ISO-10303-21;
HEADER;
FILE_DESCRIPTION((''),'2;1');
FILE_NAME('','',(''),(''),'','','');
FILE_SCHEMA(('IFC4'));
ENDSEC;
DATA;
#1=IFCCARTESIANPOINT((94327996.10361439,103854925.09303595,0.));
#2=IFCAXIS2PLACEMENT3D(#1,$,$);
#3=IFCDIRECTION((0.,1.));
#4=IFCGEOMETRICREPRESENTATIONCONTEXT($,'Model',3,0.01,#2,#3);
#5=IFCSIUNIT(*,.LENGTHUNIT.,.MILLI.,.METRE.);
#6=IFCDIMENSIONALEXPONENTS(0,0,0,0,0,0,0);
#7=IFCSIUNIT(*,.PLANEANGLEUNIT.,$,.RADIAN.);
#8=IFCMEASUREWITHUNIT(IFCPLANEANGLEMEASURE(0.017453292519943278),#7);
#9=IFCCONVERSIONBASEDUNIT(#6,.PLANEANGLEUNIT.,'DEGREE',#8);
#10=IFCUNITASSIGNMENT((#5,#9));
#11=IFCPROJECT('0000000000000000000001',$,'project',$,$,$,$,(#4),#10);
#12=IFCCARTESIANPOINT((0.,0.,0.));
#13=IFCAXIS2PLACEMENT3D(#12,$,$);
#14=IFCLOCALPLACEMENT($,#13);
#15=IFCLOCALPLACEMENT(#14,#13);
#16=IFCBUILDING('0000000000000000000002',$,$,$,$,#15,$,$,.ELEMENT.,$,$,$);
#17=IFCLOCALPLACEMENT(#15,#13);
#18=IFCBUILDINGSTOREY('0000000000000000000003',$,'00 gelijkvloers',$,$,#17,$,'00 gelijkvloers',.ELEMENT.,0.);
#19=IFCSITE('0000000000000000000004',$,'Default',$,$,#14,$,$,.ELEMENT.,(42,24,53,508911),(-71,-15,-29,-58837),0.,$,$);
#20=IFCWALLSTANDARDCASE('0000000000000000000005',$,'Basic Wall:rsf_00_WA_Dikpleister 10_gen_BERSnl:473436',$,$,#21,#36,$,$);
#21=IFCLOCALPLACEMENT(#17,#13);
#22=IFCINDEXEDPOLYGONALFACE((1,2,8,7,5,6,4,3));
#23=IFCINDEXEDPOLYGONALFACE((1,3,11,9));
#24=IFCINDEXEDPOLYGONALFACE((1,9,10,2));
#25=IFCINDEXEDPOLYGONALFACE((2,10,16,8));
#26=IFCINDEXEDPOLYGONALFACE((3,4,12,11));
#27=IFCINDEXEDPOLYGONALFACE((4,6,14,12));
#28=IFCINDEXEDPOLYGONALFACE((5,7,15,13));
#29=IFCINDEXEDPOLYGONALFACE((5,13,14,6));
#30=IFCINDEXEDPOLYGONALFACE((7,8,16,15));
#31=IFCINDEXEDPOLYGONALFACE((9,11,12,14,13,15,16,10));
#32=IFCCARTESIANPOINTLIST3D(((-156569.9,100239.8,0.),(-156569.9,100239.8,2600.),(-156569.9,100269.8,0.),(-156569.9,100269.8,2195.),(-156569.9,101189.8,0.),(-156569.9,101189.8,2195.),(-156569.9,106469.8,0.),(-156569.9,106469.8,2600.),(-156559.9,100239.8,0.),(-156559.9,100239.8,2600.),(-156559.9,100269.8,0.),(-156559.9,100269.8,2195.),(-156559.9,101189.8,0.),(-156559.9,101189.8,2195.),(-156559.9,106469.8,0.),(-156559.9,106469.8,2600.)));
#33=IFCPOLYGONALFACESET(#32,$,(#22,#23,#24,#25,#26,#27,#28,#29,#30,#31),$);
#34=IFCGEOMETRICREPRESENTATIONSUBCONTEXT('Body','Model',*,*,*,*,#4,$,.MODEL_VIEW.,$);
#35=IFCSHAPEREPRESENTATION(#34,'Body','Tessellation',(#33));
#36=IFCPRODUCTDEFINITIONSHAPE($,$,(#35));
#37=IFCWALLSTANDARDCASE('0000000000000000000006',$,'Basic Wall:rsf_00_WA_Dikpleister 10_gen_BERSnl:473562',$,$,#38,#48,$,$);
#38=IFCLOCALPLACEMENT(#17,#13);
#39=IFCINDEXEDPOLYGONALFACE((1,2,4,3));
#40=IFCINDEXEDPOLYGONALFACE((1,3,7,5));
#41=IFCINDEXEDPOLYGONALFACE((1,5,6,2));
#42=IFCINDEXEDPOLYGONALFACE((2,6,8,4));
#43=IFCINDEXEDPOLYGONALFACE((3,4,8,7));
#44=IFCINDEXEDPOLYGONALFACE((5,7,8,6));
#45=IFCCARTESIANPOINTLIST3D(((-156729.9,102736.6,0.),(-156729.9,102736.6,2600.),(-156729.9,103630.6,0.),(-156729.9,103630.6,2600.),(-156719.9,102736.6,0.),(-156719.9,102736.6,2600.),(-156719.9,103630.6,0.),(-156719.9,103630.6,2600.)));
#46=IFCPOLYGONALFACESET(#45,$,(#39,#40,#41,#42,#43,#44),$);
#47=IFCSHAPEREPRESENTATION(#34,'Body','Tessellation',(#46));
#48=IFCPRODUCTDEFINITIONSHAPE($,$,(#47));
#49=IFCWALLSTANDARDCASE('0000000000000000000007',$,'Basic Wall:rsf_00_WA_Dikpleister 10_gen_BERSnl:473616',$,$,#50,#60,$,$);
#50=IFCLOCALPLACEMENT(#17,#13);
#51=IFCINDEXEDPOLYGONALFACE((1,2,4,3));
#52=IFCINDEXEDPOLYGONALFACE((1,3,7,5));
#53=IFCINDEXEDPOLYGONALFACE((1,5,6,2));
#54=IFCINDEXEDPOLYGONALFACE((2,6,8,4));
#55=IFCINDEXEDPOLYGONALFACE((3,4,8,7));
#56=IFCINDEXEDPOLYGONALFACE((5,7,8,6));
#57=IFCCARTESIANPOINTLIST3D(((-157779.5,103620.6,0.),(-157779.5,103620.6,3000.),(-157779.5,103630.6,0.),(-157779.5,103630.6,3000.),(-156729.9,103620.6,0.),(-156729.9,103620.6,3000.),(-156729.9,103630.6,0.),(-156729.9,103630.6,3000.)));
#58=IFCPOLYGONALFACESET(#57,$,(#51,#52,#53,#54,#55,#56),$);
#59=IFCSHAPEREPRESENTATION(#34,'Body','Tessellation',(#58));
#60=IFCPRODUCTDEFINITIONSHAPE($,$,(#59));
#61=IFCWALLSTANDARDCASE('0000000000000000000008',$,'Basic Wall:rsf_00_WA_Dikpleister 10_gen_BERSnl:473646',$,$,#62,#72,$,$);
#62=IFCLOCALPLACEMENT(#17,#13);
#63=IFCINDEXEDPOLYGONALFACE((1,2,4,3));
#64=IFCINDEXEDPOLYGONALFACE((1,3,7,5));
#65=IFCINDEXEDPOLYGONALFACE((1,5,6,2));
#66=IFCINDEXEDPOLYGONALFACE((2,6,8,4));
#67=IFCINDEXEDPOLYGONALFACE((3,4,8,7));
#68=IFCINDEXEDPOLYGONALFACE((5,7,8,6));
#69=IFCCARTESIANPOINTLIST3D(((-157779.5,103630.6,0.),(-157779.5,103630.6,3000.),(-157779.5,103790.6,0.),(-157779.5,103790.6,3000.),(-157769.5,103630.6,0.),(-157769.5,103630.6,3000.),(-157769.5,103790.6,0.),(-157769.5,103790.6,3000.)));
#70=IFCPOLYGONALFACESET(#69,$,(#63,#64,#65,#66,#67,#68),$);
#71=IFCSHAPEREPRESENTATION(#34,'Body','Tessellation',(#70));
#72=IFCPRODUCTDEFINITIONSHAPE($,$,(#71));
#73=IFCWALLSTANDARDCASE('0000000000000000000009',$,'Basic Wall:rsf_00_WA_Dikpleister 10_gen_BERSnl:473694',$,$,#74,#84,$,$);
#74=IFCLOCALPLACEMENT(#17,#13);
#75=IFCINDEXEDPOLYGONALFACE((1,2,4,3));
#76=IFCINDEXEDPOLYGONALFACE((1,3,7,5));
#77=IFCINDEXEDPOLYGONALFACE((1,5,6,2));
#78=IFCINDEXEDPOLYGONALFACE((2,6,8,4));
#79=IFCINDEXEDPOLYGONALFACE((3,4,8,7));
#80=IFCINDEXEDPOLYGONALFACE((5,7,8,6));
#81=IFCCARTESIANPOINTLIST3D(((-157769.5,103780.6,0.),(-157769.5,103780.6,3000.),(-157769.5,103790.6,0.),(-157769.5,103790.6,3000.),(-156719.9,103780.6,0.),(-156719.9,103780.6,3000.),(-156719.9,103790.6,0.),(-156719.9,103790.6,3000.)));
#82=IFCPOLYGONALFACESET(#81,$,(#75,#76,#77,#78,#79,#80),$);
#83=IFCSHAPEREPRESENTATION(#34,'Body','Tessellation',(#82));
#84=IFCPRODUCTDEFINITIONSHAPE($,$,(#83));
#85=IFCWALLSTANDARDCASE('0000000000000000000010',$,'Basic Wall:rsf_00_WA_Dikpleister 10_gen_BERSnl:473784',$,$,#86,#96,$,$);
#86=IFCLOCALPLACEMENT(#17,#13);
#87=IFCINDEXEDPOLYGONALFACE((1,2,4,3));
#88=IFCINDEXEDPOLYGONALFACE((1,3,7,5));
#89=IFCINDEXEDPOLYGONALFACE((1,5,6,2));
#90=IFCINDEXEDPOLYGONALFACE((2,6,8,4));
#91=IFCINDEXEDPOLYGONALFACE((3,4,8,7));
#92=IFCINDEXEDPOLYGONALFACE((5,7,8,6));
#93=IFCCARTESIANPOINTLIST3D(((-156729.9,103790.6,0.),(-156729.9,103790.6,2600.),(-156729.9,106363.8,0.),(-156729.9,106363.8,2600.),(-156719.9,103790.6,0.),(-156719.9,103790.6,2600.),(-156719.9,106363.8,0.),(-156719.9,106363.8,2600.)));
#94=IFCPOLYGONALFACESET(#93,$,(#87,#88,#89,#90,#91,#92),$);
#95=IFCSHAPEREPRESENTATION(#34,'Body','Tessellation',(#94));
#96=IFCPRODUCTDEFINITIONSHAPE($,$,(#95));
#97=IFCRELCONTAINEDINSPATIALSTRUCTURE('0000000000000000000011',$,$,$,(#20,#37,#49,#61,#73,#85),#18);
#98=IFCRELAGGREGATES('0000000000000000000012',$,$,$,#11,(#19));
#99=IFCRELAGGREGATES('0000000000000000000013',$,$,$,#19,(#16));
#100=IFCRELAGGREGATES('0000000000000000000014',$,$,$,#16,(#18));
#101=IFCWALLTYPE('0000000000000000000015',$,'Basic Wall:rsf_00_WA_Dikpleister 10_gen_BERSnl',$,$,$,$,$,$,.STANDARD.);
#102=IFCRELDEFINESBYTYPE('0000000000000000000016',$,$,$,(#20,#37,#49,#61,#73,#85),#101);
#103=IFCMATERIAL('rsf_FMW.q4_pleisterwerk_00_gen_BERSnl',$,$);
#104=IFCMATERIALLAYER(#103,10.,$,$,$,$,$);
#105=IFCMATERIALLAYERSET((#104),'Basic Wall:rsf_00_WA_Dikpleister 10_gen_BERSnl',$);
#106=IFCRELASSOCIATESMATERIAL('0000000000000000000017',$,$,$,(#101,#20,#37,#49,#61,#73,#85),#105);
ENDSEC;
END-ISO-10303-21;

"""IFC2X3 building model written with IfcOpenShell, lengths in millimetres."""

from ifc_helpers import new_model, entity, si_unit, converted_unit, direction, frame, frame_2d, origin, place, context, subcontext, project, spatial, rectangle, extrude, material, layer, layer_set, layer_usage, type_object, element, save


model = new_model("IFC2X3")

# Units and contexts
model_context = context("Model", 3, precision=0.01, world=frame((94327996.10361439, 103854925.09303595, 0.0)), true_north=direction((0.0, 1.0)))
body_context = subcontext(model_context, "Body", "Model", "MODEL_VIEW")
ifc_project = project(units=[si_unit("LENGTHUNIT", "METRE", prefix="MILLI"), converted_unit("PLANEANGLEUNIT", "DEGREE", entity("IfcPlaneAngleMeasure", 0.017453292519943278), si_unit("PLANEANGLEUNIT", "RADIAN"), dimensions=[0, 0, 0, 0, 0, 0, 0])], contexts=[model_context])

# Site, building, storey
site_placement = place(None, origin())
site = spatial("IfcSite", under=ifc_project, at=site_placement, Name="Default", CompositionType="ELEMENT", RefLatitude=(42, 24, 53, 508911), RefLongitude=(-71, -15, -29, -58837), RefElevation=0.0)
building_placement = place(site_placement, origin())
building = spatial("IfcBuilding", under=site, at=building_placement, CompositionType="ELEMENT")
storey_placement = place(building_placement, origin())
storey = spatial("IfcBuildingStorey", under=building, at=storey_placement, Name="00 gelijkvloers", LongName="00 gelijkvloers", CompositionType="ELEMENT", Elevation=0.0)

# Shared definitions
ifc_material_1 = material(Name="rsf_FMW.q4_pleisterwerk_00_gen_BERSnl")

# Shared definitions
ifc_layer_1 = layer(ifc_material_1, 10.0)
ifc_layer_set_1 = layer_set([ifc_layer_1], Name="Basic Wall:rsf_00_WA_Dikpleister 10_gen_BERSnl")
wall_type_1 = type_object("IfcWallType", Name="Basic Wall:rsf_00_WA_Dikpleister 10_gen_BERSnl", PredefinedType="STANDARD", material=ifc_layer_set_1)

# Wall, opening
ifc_layer_usage_1 = layer_usage(ifc_layer_set_1, "AXIS2", "NEGATIVE", 5.0)
wall_1_placement = place(storey_placement, frame((-156564.9, 106469.8, 0.0), z_axis=(0.0, 0.0, 1.0), x_axis=(0.0, -1.0, 0.0)))
wall_1 = element("IfcWallStandardCase", 1, at=wall_1_placement, inside=storey, type_object=wall_type_1, material=ifc_layer_usage_1, Name="Basic Wall:rsf_00_WA_Dikpleister 10_gen_BERSnl:473436", context=body_context, shape_type="SweptSolid", body=[
    extrude(rectangle(XDim=6230.0, YDim=10.0, at=frame_2d((3115.0, 0.0), x_axis=(-1.0, 0.0))), origin(), (0.0, 0.0, 1.0), 2600.0),
])
opening_1_placement = place(wall_1_placement, frame((5280.0, -5.0, -180.0)))
element("IfcOpeningElement", 2, at=opening_1_placement, cuts=wall_1, ObjectType="Opening", context=body_context, shape_type="SweptSolid", body=[
    extrude(rectangle(XDim=2375.0, YDim=920.0, at=frame_2d((1187.5, 460.0), x_axis=(-1.0, 0.0))), frame((0.0, 0.0, 0.0), z_axis=(0.0, 1.0, 0.0), x_axis=(0.0, 0.0, 1.0)), (0.0, 0.0, 1.0), 10.0),
])

# Walls
ifc_layer_usage_2 = layer_usage(ifc_layer_set_1, "AXIS2", "NEGATIVE", 5.0)
wall_2_placement = place(storey_placement, frame((-156724.9, 102736.6, 0.0), z_axis=(0.0, 0.0, 1.0), x_axis=(0.0, 1.0, 0.0)))
element("IfcWallStandardCase", 3, at=wall_2_placement, inside=storey, type_object=wall_type_1, material=ifc_layer_usage_2, Name="Basic Wall:rsf_00_WA_Dikpleister 10_gen_BERSnl:473562", context=body_context, shape_type="SweptSolid", body=[
    extrude(rectangle(XDim=894.0, YDim=10.0, at=frame_2d((447.0, 0.0), x_axis=(-1.0, 0.0))), origin(), (0.0, 0.0, 1.0), 2600.0),
])
ifc_layer_usage_3 = layer_usage(ifc_layer_set_1, "AXIS2", "NEGATIVE", 5.0)
wall_3_placement = place(storey_placement, frame((-156729.9, 103625.6, 0.0), z_axis=(0.0, 0.0, 1.0), x_axis=(-1.0, 0.0, 0.0)))
element("IfcWallStandardCase", 4, at=wall_3_placement, inside=storey, type_object=wall_type_1, material=ifc_layer_usage_3, Name="Basic Wall:rsf_00_WA_Dikpleister 10_gen_BERSnl:473616", context=body_context, shape_type="SweptSolid", body=[
    extrude(rectangle(XDim=1049.6, YDim=10.0, at=frame_2d((524.8, 0.0), x_axis=(-1.0, 0.0))), origin(), (0.0, 0.0, 1.0), 3000.0),
])
ifc_layer_usage_4 = layer_usage(ifc_layer_set_1, "AXIS2", "NEGATIVE", 5.0)
wall_4_placement = place(storey_placement, frame((-157774.5, 103630.6, 0.0), z_axis=(0.0, 0.0, 1.0), x_axis=(0.0, 1.0, 0.0)))
element("IfcWallStandardCase", 5, at=wall_4_placement, inside=storey, type_object=wall_type_1, material=ifc_layer_usage_4, Name="Basic Wall:rsf_00_WA_Dikpleister 10_gen_BERSnl:473646", context=body_context, shape_type="SweptSolid", body=[
    extrude(rectangle(XDim=160.0, YDim=10.0, at=frame_2d((80.0, 0.0), x_axis=(-1.0, 0.0))), origin(), (0.0, 0.0, 1.0), 3000.0),
])
ifc_layer_usage_5 = layer_usage(ifc_layer_set_1, "AXIS2", "NEGATIVE", 5.0)
wall_5_placement = place(storey_placement, frame((-157769.5, 103785.6, 0.0)))
element("IfcWallStandardCase", 6, at=wall_5_placement, inside=storey, type_object=wall_type_1, material=ifc_layer_usage_5, Name="Basic Wall:rsf_00_WA_Dikpleister 10_gen_BERSnl:473694", context=body_context, shape_type="SweptSolid", body=[
    extrude(rectangle(XDim=1049.6, YDim=10.0, at=frame_2d((524.8, 0.0), x_axis=(-1.0, 0.0))), origin(), (0.0, 0.0, 1.0), 3000.0),
])
ifc_layer_usage_6 = layer_usage(ifc_layer_set_1, "AXIS2", "NEGATIVE", 5.0)
wall_6_placement = place(storey_placement, frame((-156724.9, 103790.6, 0.0), z_axis=(0.0, 0.0, 1.0), x_axis=(0.0, 1.0, 0.0)))
element("IfcWallStandardCase", 7, at=wall_6_placement, inside=storey, type_object=wall_type_1, material=ifc_layer_usage_6, Name="Basic Wall:rsf_00_WA_Dikpleister 10_gen_BERSnl:473784", context=body_context, shape_type="SweptSolid", body=[
    extrude(rectangle(XDim=2573.2, YDim=10.0, at=frame_2d((1286.6, 0.0), x_axis=(-1.0, 0.0))), origin(), (0.0, 0.0, 1.0), 2600.0),
])

save(model, "model.ifc")
